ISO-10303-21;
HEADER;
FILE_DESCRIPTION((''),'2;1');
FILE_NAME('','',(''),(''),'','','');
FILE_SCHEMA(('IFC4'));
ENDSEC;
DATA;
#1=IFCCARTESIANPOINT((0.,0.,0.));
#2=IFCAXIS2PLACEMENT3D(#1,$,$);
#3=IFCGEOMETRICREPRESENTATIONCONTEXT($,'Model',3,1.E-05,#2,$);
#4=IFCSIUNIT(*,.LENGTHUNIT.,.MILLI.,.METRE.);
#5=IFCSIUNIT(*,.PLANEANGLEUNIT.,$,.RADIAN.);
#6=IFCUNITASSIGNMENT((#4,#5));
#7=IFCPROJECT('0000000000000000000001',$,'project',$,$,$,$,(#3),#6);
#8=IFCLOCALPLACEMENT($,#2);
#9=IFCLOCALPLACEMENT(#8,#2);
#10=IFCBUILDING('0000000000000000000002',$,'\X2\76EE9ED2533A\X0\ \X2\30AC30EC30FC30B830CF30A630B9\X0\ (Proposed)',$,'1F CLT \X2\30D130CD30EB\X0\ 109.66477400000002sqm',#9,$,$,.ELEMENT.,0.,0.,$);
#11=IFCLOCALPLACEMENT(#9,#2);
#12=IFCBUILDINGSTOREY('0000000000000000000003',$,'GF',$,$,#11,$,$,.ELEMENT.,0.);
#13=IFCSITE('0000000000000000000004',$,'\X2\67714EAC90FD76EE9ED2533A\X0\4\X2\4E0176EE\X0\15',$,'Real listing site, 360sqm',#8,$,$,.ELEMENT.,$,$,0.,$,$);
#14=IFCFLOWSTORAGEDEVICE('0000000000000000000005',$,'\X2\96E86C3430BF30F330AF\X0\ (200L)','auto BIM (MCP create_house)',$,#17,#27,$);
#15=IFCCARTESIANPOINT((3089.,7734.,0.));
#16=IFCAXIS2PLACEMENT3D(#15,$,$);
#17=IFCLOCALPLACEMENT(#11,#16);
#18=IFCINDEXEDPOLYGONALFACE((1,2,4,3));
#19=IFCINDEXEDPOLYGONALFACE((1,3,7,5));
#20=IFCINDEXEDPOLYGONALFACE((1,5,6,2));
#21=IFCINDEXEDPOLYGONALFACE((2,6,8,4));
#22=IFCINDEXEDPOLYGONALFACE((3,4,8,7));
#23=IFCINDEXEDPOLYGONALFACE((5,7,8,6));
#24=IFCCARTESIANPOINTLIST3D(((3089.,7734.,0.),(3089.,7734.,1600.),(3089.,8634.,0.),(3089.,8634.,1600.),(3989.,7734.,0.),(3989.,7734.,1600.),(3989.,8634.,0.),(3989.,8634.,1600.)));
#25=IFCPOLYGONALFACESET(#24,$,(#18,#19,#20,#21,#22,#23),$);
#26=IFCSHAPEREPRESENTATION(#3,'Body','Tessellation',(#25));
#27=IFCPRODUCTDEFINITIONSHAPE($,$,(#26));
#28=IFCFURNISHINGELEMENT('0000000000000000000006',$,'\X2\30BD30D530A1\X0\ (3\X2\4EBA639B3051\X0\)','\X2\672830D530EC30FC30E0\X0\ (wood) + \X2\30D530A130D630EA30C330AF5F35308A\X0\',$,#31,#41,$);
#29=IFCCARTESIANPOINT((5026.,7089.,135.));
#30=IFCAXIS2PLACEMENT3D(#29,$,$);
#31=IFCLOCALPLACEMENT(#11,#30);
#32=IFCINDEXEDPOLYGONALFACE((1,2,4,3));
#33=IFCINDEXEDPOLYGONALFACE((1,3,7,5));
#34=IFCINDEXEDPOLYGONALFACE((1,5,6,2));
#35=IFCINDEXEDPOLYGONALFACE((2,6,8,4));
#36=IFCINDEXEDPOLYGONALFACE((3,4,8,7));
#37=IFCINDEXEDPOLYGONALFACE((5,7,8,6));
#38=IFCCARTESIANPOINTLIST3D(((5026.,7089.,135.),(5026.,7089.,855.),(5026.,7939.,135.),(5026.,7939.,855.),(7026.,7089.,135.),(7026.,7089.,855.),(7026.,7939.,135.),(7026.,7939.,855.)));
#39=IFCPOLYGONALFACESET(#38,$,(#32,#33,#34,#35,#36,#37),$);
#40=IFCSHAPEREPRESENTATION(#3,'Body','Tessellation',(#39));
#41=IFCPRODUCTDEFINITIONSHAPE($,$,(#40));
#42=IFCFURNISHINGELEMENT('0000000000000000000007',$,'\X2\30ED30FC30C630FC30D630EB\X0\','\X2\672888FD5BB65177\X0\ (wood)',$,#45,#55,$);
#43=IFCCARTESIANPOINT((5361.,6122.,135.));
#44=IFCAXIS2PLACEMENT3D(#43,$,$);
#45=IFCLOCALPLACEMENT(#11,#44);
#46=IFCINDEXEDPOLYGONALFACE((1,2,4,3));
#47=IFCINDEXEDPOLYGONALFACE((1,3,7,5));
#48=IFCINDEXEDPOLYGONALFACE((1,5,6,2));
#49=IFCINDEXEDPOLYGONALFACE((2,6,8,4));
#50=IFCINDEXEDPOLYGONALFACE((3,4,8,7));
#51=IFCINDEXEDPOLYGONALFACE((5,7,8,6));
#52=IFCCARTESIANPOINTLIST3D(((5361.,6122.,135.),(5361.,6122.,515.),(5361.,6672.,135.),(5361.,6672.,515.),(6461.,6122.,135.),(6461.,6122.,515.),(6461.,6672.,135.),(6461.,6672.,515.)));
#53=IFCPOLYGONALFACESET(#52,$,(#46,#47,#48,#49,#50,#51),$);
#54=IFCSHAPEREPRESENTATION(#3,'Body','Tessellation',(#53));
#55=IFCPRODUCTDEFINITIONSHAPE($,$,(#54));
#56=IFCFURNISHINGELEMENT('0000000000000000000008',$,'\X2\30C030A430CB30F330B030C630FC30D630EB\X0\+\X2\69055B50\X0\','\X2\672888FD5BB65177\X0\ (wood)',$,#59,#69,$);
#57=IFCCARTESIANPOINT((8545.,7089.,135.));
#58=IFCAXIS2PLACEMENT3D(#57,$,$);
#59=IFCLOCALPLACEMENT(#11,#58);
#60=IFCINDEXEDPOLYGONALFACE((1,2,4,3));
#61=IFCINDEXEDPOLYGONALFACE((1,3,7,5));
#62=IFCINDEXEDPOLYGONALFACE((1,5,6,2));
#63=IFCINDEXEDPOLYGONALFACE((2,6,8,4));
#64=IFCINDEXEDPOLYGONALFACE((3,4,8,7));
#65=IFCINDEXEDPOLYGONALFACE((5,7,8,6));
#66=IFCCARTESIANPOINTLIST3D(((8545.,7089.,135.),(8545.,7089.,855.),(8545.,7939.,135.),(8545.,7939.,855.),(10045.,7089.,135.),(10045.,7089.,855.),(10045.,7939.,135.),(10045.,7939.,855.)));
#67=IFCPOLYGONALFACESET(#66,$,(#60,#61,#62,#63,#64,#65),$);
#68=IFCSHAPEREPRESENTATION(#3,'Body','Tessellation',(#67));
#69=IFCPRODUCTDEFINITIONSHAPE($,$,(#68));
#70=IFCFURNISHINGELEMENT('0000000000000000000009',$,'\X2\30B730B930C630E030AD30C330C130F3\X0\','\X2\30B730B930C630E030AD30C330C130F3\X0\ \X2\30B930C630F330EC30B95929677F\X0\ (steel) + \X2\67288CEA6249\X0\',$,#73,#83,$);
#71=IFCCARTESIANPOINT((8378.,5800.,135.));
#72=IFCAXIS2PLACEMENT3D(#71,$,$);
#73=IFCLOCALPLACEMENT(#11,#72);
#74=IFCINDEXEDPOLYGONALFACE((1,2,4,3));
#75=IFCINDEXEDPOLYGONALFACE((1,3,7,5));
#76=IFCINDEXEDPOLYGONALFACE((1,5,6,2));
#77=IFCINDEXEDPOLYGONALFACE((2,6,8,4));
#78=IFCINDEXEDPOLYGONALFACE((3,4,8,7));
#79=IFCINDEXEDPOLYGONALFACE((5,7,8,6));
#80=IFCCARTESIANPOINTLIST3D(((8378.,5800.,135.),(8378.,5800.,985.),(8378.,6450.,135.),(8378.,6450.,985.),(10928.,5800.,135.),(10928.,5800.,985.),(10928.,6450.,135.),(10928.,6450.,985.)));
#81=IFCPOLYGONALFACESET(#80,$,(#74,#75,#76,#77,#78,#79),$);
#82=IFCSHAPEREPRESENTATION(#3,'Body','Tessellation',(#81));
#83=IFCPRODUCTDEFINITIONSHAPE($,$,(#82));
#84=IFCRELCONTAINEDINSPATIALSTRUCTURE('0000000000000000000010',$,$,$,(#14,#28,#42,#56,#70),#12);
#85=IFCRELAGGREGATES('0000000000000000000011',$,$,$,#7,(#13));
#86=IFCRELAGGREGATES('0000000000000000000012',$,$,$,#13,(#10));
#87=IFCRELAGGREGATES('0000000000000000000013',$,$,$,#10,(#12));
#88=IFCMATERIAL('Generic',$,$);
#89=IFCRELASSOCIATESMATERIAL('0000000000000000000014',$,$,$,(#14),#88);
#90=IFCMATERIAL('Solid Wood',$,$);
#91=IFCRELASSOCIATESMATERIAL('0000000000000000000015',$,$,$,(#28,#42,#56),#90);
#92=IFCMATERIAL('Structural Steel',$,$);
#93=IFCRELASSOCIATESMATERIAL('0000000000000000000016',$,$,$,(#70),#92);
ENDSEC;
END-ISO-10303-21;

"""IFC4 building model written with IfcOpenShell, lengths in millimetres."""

from ifc_helpers import new_model, si_unit, frame, frame_2d, origin, place, context, project, spatial, rectangle, extrude, material, element, save


model = new_model("IFC4")

# Units and contexts
model_context = context("Model", 3, precision=1e-05, world=origin())
ifc_project = project(units=[si_unit("LENGTHUNIT", "METRE", prefix="MILLI"), si_unit("PLANEANGLEUNIT", "RADIAN")], contexts=[model_context])

# Site, building, storey
site_placement = place(None, origin())
site = spatial("IfcSite", under=ifc_project, at=site_placement, Name="東京都目黒区4丁目15", ObjectType="Real listing site, 360sqm", CompositionType="ELEMENT", RefElevation=0.0)
building_placement = place(site_placement, origin())
building = spatial("IfcBuilding", under=site, at=building_placement, Name="目黒区 ガレージハウス (Proposed)", ObjectType="1F CLT パネル 109.66477400000002sqm", CompositionType="ELEMENT", ElevationOfRefHeight=0.0, ElevationOfTerrain=0.0)
storey_placement = place(building_placement, origin())
storey = spatial("IfcBuildingStorey", under=building, at=storey_placement, Name="GF", CompositionType="ELEMENT", Elevation=0.0)

# Shared definitions
ifc_material_1 = material(Name="Solid Wood")

# Shared definitions
ifc_material_2 = material(Name="Structural Steel")

# Shared definitions
ifc_material_3 = material(Name="Generic")

# Flow storage device
flow_storage_device_placement = place(storey_placement, frame((3089.0, 7734.0, 0.0)))
element("IfcFlowStorageDevice", 1, at=flow_storage_device_placement, inside=storey, material=ifc_material_3, Name="雨水タンク (200L)", Description="auto BIM (MCP create_house)", context=model_context, shape_type="SweptSolid", body=[
    extrude(rectangle(XDim=900.0, YDim=900.0, at=frame_2d((450.0, 450.0))), frame((3089.0, 7734.0, 0.0)), (0.0, 0.0, 1.0), 1600.0),
])

# Furnishing elements
furnishing_1_placement = place(storey_placement, frame((5026.0, 7089.0, 135.0)))
element("IfcFurnishingElement", 2, at=furnishing_1_placement, inside=storey, material=ifc_material_1, Name="ソファ (3人掛け)", Description="木フレーム (wood) + ファブリック張り", context=model_context, shape_type="SweptSolid", body=[
    extrude(rectangle(XDim=2000.0, YDim=850.0, at=frame_2d((1000.0, 425.0))), frame((5026.0, 7089.0, 135.0)), (0.0, 0.0, 1.0), 720.0),
])
furnishing_2_placement = place(storey_placement, frame((5361.0, 6122.0, 135.0)))
element("IfcFurnishingElement", 3, at=furnishing_2_placement, inside=storey, material=ifc_material_1, Name="ローテーブル", Description="木製家具 (wood)", context=model_context, shape_type="SweptSolid", body=[
    extrude(rectangle(XDim=1100.0, YDim=550.0, at=frame_2d((550.0, 275.0))), frame((5361.0, 6122.0, 135.0)), (0.0, 0.0, 1.0), 380.0),
])
furnishing_3_placement = place(storey_placement, frame((8545.0, 7089.0, 135.0)))
element("IfcFurnishingElement", 4, at=furnishing_3_placement, inside=storey, material=ifc_material_1, Name="ダイニングテーブル+椅子", Description="木製家具 (wood)", context=model_context, shape_type="SweptSolid", body=[
    extrude(rectangle(XDim=1500.0, YDim=850.0, at=frame_2d((750.0, 425.0))), frame((8545.0, 7089.0, 135.0)), (0.0, 0.0, 1.0), 720.0),
])
furnishing_4_placement = place(storey_placement, frame((8378.0, 5800.0, 135.0)))
element("IfcFurnishingElement", 5, at=furnishing_4_placement, inside=storey, material=ifc_material_2, Name="システムキッチン", Description="システムキッチン ステンレス天板 (steel) + 木質扉", context=model_context, shape_type="SweptSolid", body=[
    extrude(rectangle(XDim=2550.0, YDim=650.0, at=frame_2d((1275.0, 325.0))), frame((8378.0, 5800.0, 135.0)), (0.0, 0.0, 1.0), 850.0),
])

save(model, "model.ifc")
